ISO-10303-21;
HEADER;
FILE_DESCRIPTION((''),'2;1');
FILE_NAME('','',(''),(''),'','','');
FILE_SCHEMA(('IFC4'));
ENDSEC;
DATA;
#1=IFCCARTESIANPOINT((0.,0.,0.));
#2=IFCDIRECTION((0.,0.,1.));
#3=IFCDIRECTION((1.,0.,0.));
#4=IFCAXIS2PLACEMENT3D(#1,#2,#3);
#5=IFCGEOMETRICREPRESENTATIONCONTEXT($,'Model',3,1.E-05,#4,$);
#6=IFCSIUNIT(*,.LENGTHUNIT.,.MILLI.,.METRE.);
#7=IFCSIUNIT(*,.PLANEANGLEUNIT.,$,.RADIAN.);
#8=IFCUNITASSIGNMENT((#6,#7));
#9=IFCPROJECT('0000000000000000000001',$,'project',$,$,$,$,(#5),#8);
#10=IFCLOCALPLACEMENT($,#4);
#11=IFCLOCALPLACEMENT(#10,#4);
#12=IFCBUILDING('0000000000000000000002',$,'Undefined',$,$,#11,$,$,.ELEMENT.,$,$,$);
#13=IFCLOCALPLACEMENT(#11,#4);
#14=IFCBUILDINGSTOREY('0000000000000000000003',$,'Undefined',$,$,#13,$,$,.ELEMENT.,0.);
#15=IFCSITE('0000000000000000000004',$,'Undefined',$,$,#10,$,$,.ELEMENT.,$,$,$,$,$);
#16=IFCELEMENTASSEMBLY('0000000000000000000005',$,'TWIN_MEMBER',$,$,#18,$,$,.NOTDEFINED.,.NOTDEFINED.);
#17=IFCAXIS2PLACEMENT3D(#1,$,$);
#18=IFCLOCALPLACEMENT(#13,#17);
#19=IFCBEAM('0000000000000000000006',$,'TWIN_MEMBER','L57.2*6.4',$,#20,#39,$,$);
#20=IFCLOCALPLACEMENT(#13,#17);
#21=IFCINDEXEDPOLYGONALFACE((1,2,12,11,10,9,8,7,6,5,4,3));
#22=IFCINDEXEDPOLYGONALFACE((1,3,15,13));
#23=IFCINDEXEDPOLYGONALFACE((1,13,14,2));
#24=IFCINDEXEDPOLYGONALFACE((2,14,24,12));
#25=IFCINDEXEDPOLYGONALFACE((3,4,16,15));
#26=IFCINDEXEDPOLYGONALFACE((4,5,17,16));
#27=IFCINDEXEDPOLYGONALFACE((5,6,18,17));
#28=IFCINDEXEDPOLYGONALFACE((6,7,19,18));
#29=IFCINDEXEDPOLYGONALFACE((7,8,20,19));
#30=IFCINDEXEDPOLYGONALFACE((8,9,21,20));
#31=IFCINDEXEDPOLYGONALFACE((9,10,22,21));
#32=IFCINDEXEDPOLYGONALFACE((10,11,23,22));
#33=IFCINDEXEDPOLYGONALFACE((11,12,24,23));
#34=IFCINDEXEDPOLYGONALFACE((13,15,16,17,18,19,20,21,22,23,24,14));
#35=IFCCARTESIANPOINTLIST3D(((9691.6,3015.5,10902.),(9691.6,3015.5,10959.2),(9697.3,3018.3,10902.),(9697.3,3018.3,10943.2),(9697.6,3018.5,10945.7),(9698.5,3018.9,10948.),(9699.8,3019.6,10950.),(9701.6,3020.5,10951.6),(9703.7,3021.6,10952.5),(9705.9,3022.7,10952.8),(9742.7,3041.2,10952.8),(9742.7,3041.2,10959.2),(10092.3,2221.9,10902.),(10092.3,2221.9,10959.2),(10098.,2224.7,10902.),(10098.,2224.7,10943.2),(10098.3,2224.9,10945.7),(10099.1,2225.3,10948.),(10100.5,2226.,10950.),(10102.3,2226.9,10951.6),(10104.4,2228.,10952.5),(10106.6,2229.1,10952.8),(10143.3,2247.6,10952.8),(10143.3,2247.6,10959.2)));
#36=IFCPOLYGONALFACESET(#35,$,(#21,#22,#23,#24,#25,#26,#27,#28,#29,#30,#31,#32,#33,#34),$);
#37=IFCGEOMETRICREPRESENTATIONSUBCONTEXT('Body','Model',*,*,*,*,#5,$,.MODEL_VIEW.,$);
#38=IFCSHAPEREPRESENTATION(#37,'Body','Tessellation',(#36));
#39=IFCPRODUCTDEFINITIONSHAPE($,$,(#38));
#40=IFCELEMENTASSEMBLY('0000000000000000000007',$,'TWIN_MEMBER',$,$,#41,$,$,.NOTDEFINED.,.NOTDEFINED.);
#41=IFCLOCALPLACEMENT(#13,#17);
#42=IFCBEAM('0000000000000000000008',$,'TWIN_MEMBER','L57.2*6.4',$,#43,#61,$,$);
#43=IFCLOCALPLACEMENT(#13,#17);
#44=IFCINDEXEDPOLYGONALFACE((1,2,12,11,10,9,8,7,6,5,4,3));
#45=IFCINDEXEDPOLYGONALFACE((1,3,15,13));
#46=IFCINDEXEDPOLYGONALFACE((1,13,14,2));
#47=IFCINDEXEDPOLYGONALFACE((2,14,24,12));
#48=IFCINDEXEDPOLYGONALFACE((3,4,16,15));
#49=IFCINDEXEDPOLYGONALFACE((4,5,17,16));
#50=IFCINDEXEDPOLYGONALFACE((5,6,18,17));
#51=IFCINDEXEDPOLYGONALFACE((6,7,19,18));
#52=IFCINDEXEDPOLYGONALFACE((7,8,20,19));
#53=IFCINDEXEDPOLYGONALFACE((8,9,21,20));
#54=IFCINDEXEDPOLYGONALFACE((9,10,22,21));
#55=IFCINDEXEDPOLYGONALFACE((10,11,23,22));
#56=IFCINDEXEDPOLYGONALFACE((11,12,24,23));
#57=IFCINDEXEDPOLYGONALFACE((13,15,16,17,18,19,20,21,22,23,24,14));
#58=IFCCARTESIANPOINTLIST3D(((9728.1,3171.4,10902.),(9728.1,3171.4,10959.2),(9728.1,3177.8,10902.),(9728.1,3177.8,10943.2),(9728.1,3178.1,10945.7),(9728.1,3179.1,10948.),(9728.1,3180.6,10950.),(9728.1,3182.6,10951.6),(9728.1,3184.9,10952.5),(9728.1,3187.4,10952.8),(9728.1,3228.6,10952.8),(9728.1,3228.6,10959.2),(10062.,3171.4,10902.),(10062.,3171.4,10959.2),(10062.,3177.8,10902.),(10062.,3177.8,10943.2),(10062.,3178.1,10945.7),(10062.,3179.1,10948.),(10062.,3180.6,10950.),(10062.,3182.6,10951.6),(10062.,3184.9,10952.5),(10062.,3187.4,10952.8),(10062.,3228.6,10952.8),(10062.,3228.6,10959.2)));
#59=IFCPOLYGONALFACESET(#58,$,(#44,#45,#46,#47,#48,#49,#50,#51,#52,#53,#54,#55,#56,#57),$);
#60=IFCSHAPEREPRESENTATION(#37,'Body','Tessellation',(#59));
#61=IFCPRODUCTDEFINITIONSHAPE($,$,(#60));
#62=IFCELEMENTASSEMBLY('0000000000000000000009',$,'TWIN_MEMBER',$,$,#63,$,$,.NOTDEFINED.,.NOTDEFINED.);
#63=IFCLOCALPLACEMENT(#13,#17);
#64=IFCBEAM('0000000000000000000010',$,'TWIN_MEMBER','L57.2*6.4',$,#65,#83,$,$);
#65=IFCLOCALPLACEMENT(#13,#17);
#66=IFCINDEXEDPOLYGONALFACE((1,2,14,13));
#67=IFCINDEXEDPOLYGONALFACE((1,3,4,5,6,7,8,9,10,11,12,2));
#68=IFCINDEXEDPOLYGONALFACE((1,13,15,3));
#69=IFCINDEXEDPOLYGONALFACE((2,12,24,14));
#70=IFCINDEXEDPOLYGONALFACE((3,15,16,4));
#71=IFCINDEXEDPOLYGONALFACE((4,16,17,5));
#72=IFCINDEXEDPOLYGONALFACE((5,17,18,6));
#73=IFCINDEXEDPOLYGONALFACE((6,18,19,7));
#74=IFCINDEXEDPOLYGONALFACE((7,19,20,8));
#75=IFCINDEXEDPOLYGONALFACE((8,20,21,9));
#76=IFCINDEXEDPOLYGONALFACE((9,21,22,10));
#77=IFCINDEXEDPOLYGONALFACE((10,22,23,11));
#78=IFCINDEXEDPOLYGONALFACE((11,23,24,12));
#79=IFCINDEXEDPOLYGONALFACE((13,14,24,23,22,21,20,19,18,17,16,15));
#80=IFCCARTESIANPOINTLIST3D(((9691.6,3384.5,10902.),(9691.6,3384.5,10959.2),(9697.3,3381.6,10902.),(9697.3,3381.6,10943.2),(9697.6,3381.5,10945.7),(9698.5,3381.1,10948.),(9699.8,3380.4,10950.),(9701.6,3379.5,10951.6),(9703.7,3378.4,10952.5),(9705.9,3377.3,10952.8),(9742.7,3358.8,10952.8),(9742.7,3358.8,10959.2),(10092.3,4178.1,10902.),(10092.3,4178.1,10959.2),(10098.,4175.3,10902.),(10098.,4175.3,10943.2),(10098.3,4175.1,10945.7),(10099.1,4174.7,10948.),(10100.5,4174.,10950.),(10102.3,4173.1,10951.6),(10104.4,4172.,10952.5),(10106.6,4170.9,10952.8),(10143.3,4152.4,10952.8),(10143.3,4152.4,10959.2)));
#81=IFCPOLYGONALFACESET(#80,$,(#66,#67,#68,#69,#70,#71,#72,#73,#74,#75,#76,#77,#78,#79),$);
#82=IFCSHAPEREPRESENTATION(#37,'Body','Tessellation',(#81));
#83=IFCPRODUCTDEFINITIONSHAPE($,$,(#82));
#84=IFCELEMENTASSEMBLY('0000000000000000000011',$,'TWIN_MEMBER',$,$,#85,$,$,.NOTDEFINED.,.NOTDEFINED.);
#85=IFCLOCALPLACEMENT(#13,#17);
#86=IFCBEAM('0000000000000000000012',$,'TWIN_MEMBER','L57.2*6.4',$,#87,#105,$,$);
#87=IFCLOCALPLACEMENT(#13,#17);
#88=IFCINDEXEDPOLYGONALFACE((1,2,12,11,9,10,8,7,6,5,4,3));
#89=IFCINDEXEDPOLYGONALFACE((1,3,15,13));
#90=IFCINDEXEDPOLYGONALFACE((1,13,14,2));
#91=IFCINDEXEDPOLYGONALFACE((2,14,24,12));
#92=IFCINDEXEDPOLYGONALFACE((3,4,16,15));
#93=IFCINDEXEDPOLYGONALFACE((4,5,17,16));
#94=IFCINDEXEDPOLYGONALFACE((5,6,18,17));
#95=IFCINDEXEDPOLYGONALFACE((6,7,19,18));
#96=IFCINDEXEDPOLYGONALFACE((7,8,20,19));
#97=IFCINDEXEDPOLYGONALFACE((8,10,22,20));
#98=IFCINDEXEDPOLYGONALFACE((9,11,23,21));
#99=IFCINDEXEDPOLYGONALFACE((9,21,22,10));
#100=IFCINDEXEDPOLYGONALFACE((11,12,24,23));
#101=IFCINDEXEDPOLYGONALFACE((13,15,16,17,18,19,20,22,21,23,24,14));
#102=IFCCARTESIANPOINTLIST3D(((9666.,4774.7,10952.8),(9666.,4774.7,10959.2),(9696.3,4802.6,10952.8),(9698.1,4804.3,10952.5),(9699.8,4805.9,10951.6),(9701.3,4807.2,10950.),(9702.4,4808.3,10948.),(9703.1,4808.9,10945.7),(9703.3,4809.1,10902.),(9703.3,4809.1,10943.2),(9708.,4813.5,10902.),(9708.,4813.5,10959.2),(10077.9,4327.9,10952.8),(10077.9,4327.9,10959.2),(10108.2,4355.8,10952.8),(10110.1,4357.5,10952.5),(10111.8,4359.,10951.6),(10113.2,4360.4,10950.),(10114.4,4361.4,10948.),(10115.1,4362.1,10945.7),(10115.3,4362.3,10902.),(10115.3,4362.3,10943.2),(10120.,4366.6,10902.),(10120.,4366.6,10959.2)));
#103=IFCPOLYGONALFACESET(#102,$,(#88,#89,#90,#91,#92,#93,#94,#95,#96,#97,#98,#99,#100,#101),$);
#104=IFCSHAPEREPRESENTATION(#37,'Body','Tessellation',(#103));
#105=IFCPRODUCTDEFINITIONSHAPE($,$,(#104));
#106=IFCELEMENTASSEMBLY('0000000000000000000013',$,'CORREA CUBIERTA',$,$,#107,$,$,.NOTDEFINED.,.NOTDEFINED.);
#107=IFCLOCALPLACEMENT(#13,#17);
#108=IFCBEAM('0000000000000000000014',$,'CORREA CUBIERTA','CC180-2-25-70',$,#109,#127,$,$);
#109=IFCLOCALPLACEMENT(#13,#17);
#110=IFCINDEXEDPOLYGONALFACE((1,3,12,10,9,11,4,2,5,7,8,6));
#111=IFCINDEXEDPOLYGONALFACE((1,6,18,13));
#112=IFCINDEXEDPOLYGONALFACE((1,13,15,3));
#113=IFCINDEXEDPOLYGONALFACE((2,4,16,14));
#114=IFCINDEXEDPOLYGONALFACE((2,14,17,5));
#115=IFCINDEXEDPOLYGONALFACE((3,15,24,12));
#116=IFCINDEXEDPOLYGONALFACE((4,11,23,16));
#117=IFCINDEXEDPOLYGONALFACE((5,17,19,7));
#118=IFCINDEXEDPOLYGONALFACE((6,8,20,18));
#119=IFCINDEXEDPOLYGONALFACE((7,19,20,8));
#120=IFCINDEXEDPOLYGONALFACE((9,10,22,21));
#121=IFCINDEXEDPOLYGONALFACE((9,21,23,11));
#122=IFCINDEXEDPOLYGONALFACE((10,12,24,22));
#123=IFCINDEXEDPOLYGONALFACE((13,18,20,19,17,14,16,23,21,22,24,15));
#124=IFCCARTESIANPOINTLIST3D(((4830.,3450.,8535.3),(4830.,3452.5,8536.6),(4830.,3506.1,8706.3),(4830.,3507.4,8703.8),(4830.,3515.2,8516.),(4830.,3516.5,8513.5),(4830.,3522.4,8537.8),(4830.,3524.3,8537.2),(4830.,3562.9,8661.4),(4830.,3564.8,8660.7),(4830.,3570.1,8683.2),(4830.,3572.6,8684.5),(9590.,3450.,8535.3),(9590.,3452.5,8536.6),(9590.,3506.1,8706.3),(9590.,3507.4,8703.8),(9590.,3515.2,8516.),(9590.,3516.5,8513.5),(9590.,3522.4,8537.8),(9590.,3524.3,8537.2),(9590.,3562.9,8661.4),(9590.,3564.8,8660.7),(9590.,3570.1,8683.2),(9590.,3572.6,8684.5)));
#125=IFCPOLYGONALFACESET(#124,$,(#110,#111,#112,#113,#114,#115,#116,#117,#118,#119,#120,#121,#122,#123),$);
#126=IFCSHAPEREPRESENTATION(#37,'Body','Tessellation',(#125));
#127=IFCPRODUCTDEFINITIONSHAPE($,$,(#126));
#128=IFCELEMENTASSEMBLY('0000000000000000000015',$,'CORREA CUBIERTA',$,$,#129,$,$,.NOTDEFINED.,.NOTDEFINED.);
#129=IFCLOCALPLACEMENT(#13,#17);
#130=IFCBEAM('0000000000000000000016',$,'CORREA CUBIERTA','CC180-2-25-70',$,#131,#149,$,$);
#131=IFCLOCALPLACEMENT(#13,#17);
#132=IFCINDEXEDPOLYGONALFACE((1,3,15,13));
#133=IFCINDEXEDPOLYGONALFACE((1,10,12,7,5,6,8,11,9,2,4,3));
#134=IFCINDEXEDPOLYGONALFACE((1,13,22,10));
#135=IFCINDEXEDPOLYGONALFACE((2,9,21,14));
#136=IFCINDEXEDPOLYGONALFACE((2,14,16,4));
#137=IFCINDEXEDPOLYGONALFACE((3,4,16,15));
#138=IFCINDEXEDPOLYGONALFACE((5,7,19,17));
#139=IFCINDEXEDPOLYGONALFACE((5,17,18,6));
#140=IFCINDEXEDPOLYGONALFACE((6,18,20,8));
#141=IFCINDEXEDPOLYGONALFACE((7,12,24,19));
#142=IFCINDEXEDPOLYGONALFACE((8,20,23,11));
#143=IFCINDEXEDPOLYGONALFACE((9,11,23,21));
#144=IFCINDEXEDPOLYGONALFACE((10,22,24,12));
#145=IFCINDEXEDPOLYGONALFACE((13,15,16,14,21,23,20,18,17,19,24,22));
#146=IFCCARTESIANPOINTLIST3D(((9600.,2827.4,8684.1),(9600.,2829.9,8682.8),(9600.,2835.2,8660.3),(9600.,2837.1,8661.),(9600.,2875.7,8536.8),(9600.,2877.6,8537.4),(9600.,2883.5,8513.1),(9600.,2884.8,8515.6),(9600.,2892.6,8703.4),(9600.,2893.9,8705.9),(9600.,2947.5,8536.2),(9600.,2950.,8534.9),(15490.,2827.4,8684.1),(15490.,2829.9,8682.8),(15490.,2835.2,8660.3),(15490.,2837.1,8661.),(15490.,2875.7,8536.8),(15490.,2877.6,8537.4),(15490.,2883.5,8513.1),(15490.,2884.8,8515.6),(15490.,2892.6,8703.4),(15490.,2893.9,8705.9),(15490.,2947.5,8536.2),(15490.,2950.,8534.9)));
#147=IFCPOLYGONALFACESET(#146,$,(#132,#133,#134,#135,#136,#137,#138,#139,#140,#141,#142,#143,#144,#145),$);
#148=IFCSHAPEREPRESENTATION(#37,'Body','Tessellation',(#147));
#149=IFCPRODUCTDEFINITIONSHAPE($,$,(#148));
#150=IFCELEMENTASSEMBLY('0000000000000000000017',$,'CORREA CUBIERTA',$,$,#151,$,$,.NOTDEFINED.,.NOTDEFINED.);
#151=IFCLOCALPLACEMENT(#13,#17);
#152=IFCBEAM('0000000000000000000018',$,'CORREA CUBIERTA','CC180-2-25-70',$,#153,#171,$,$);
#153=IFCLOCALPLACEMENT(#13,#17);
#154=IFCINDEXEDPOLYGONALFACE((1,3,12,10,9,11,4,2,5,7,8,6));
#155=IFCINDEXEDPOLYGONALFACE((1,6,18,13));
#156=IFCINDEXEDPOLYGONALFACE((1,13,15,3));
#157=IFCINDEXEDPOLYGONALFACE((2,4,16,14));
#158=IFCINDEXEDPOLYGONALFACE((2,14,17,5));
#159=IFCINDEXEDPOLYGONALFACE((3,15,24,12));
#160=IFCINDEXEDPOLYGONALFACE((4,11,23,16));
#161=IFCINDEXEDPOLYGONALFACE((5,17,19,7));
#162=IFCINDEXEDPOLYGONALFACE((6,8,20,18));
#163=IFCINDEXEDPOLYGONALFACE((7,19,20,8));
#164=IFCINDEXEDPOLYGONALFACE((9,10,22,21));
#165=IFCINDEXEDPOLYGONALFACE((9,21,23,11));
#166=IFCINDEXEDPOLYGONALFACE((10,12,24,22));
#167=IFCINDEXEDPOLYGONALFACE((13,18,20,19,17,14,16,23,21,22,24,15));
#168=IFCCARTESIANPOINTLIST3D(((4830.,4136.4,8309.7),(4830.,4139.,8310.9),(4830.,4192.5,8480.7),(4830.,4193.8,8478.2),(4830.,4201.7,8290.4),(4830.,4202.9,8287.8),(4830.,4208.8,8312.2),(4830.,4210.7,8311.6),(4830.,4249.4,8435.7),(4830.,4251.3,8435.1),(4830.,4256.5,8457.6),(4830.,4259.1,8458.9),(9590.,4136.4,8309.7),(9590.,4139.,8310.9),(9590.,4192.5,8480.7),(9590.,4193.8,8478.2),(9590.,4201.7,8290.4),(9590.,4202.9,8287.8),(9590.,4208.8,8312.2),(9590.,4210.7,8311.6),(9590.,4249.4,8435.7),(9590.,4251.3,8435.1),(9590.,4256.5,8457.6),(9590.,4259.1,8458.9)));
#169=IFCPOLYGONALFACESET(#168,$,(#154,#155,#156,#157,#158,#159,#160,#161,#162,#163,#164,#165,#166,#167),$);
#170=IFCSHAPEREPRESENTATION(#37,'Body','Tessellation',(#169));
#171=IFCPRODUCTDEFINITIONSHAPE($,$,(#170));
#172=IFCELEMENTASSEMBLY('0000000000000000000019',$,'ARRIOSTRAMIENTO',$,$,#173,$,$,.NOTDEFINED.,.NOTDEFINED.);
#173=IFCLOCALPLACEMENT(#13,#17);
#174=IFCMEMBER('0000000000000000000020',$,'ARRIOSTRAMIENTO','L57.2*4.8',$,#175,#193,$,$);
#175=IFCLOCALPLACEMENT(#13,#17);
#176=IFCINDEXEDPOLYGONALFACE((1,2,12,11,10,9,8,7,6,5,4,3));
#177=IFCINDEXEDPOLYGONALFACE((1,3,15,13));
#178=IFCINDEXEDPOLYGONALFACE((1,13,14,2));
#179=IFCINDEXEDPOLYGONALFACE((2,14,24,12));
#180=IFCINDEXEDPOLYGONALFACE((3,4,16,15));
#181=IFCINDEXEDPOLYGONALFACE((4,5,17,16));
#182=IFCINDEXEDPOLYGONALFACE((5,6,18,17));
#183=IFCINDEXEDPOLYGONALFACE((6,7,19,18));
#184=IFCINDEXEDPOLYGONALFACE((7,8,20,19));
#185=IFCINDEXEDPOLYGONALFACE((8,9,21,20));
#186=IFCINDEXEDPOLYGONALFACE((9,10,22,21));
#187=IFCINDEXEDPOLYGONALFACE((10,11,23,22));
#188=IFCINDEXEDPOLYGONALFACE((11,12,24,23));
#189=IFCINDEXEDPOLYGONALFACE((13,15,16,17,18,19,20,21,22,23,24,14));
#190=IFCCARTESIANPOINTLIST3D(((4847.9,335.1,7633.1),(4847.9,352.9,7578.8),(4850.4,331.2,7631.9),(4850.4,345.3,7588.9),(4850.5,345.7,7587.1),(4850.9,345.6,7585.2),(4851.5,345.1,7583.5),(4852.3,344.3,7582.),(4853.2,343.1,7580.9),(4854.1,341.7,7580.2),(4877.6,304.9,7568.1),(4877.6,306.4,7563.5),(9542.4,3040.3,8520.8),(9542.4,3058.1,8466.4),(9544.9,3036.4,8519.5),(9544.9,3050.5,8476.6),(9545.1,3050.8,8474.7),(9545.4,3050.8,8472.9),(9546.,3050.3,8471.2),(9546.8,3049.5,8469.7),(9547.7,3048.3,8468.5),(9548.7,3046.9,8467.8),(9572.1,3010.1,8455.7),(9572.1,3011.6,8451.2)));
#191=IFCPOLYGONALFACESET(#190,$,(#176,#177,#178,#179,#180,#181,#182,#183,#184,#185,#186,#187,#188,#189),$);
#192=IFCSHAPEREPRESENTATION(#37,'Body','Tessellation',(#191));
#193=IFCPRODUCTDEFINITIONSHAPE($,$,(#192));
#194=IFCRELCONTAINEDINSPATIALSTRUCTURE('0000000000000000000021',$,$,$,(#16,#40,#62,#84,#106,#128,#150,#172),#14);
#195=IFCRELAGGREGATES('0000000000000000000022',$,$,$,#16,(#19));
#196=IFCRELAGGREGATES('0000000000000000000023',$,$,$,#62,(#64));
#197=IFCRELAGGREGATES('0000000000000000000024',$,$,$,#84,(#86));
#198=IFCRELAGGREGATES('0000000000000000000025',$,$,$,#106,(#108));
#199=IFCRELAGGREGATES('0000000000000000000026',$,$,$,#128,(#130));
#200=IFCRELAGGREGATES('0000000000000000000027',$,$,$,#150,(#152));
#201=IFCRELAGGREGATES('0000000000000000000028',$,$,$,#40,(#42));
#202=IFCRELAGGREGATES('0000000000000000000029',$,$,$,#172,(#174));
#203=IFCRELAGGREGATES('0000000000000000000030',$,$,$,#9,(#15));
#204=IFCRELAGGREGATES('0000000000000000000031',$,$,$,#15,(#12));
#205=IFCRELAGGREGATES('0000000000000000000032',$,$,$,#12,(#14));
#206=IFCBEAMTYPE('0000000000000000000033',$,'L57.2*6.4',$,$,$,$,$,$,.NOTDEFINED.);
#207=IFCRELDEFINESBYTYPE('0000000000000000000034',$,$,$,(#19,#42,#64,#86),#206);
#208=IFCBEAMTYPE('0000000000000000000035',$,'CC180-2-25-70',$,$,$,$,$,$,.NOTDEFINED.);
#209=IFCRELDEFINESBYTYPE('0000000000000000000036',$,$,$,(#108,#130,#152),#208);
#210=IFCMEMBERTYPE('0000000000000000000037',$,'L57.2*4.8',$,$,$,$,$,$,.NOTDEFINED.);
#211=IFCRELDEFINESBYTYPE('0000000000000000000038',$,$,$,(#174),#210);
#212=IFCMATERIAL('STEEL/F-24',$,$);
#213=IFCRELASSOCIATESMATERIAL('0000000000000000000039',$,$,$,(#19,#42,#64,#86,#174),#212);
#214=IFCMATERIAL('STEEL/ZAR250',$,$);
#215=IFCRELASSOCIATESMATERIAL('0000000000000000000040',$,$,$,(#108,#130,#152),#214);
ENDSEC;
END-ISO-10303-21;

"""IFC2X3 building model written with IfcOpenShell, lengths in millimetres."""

from ifc_helpers import new_model, si_unit, frame, origin_with_axes, origin_2d_with_axis, place, context, subcontext, project, spatial, l_section, c_section, extrude, clip, halfspace, material, type_object, element, aggregate, save


model = new_model("IFC2X3")

# Units and contexts
model_context = context("Model", 3, precision=1e-05, world=origin_with_axes())
body_context = subcontext(model_context, "Body", "Model", "MODEL_VIEW")
ifc_project = project(units=[si_unit("LENGTHUNIT", "METRE", prefix="MILLI"), si_unit("PLANEANGLEUNIT", "RADIAN")], contexts=[model_context])

# Site, building, storey
site_placement = place(None, origin_with_axes())
site = spatial("IfcSite", under=ifc_project, at=site_placement, Name="Undefined", CompositionType="ELEMENT")
building_placement = place(site_placement, origin_with_axes())
building = spatial("IfcBuilding", under=site, at=building_placement, Name="Undefined", CompositionType="ELEMENT")
storey_placement = place(building_placement, origin_with_axes())
storey = spatial("IfcBuildingStorey", under=building, at=storey_placement, Name="Undefined", CompositionType="ELEMENT", Elevation=0.0)

# Element assemblies, beams
assembly_1_placement = place(storey_placement, origin_with_axes())
assembly_1 = element("IfcElementAssembly", 1, at=assembly_1_placement, inside=storey, Name="TWIN_MEMBER", AssemblyPlace="NOTDEFINED", PredefinedType="NOTDEFINED")
ifc_material_1 = material(Name="STEEL/F-24")
beam_type_1 = type_object("IfcBeamType", Name="L57.2*6.4", PredefinedType="NOTDEFINED")
beam_1_placement = place(assembly_1_placement, frame((9717.1, 3028.4, 10930.6), z_axis=(0.0, 0.0, -1.0), x_axis=(0.450691, -0.89268, 0.0)))
beam_1 = element("IfcBeam", 2, at=beam_1_placement, type_object=beam_type_1, material=ifc_material_1, Name="TWIN_MEMBER", Description="L57.2*6.4", context=body_context, shape_type="SweptSolid", body=[
    extrude(l_section(Depth=57.2, Width=57.2, Thickness=6.4, FilletRadius=9.6, at=origin_2d_with_axis()), frame((889.0, 0.0, 0.0), z_axis=(-1.0, 0.0, 0.0), x_axis=(0.0, -1.0, 0.0)), (0.0, 0.0, 1.0), 889.0),
])
aggregate(assembly_1, [beam_1])
assembly_2_placement = place(storey_placement, origin_with_axes())
assembly_2 = element("IfcElementAssembly", 3, at=assembly_2_placement, inside=storey, Name="TWIN_MEMBER", AssemblyPlace="NOTDEFINED", PredefinedType="NOTDEFINED")
beam_2_placement = place(assembly_2_placement, frame((9728.1, 3200.0, 10930.6), z_axis=(0.0, 0.0, -1.0), x_axis=(1.0, 0.0, 0.0)))
beam_2 = element("IfcBeam", 4, at=beam_2_placement, type_object=beam_type_1, material=ifc_material_1, Name="TWIN_MEMBER", Description="L57.2*6.4", context=body_context, shape_type="SweptSolid", body=[
    extrude(l_section(Depth=57.2, Width=57.2, Thickness=6.4, FilletRadius=9.6, at=origin_2d_with_axis()), frame((333.9, 0.0, 0.0), z_axis=(-1.0, 0.0, 0.0), x_axis=(0.0, -1.0, 0.0)), (0.0, 0.0, 1.0), 333.9),
])
assembly_3_placement = place(storey_placement, origin_with_axes())
assembly_3 = element("IfcElementAssembly", 5, at=assembly_3_placement, inside=storey, Name="TWIN_MEMBER", AssemblyPlace="NOTDEFINED", PredefinedType="NOTDEFINED")
beam_3_placement = place(assembly_3_placement, frame((10117.8, 4165.2, 10930.6), z_axis=(0.0, 0.0, -1.0), x_axis=(-0.450691, -0.89268, 0.0)))
beam_3 = element("IfcBeam", 6, at=beam_3_placement, type_object=beam_type_1, material=ifc_material_1, Name="TWIN_MEMBER", Description="L57.2*6.4", context=body_context, shape_type="SweptSolid", body=[
    extrude(l_section(Depth=57.2, Width=57.2, Thickness=6.4, FilletRadius=9.6, at=origin_2d_with_axis()), frame((889.0, 0.0, 0.0), z_axis=(-1.0, 0.0, 0.0), x_axis=(0.0, -1.0, 0.0)), (0.0, 0.0, 1.0), 889.0),
])
aggregate(assembly_3, [beam_3])
assembly_4_placement = place(storey_placement, origin_with_axes())
assembly_4 = element("IfcElementAssembly", 7, at=assembly_4_placement, inside=storey, Name="TWIN_MEMBER", AssemblyPlace="NOTDEFINED", PredefinedType="NOTDEFINED")
beam_4_placement = place(assembly_4_placement, frame((10099.0, 4347.3, 10930.6), z_axis=(0.0, 0.0, -1.0), x_axis=(-0.677842, 0.735208, 0.0)))
beam_4 = element("IfcBeam", 8, at=beam_4_placement, type_object=beam_type_1, material=ifc_material_1, Name="TWIN_MEMBER", Description="L57.2*6.4", context=body_context, shape_type="SweptSolid", body=[
    extrude(l_section(Depth=57.2, Width=57.2, Thickness=6.4, FilletRadius=9.6, at=origin_2d_with_axis()), frame((607.8, 0.0, 0.0), z_axis=(-1.0, 0.0, 0.0), x_axis=(0.0, -1.0, 0.0)), (0.0, 0.0, 1.0), 607.8),
])
aggregate(assembly_4, [beam_4])
assembly_5_placement = place(storey_placement, origin_with_axes())
assembly_5 = element("IfcElementAssembly", 9, at=assembly_5_placement, inside=storey, Name="CORREA CUBIERTA", AssemblyPlace="NOTDEFINED", PredefinedType="NOTDEFINED")
ifc_material_2 = material(Name="STEEL/ZAR250")
beam_type_2 = type_object("IfcBeamType", Name="CC180-2-25-70", PredefinedType="NOTDEFINED")
beam_5_placement = place(assembly_5_placement, frame((9590.0, 3511.3, 8609.9), z_axis=(0.0, 0.311771, 0.950157), x_axis=(-1.0, 0.0, 0.0)))
beam_5 = element("IfcBeam", 10, at=beam_5_placement, type_object=beam_type_2, material=ifc_material_2, Name="CORREA CUBIERTA", Description="CC180-2-25-70", context=body_context, shape_type="SweptSolid", body=[
    extrude(c_section(Depth=180.0, Width=70.0, WallThickness=2.0, Girth=25.0, at=origin_2d_with_axis()), frame((4760.0, 0.0, 0.0), z_axis=(-1.0, 0.0, 0.0), x_axis=(0.0, -1.0, 0.0)), (0.0, 0.0, 1.0), 4760.0),
])
aggregate(assembly_5, [beam_5])
assembly_6_placement = place(storey_placement, origin_with_axes())
assembly_6 = element("IfcElementAssembly", 11, at=assembly_6_placement, inside=storey, Name="CORREA CUBIERTA", AssemblyPlace="NOTDEFINED", PredefinedType="NOTDEFINED")
beam_6_placement = place(assembly_6_placement, frame((9600.0, 2888.7, 8609.5), z_axis=(0.0, -0.311771, 0.950157), x_axis=(1.0, 0.0, 0.0)))
beam_6 = element("IfcBeam", 12, at=beam_6_placement, type_object=beam_type_2, material=ifc_material_2, Name="CORREA CUBIERTA", Description="CC180-2-25-70", context=body_context, shape_type="SweptSolid", body=[
    extrude(c_section(Depth=180.0, Width=70.0, WallThickness=2.0, Girth=25.0, at=origin_2d_with_axis()), frame((5890.0, 0.0, 0.0), z_axis=(-1.0, 0.0, 0.0), x_axis=(0.0, -1.0, 0.0)), (0.0, 0.0, 1.0), 5890.0),
])
aggregate(assembly_6, [beam_6])
assembly_7_placement = place(storey_placement, origin_with_axes())
assembly_7 = element("IfcElementAssembly", 13, at=assembly_7_placement, inside=storey, Name="CORREA CUBIERTA", AssemblyPlace="NOTDEFINED", PredefinedType="NOTDEFINED")
beam_7_placement = place(assembly_7_placement, frame((9590.0, 4197.7, 8384.3), z_axis=(0.0, 0.311771, 0.950157), x_axis=(-1.0, 0.0, 0.0)))
beam_7 = element("IfcBeam", 14, at=beam_7_placement, type_object=beam_type_2, material=ifc_material_2, Name="CORREA CUBIERTA", Description="CC180-2-25-70", context=body_context, shape_type="SweptSolid", body=[
    extrude(c_section(Depth=180.0, Width=70.0, WallThickness=2.0, Girth=25.0, at=origin_2d_with_axis()), frame((4760.0, 0.0, 0.0), z_axis=(-1.0, 0.0, 0.0), x_axis=(0.0, -1.0, 0.0)), (0.0, 0.0, 1.0), 4760.0),
])
aggregate(assembly_7, [beam_7])

# Element assembly, member
assembly_8_placement = place(storey_placement, origin_with_axes())
assembly_8 = element("IfcElementAssembly", 15, at=assembly_8_placement, inside=storey, Name="ARRIOSTRAMIENTO", AssemblyPlace="NOTDEFINED", PredefinedType="NOTDEFINED")
member_type = type_object("IfcMemberType", Name="L57.2*4.8", PredefinedType="NOTDEFINED")
member_1_placement = place(assembly_8_placement, frame((9595.0, 3047.7, 8493.1), z_axis=(0.518558, -0.812425, -0.266577), x_axis=(-0.855043, -0.492712, -0.161671)))
member_1 = element("IfcMember", 16, at=member_1_placement, type_object=member_type, material=ifc_material_1, Name="ARRIOSTRAMIENTO", Description="L57.2*4.8", context=body_context, shape_type="Clipping", body=[
    clip(clip(extrude(l_section(Depth=57.2, Width=57.2, Thickness=4.8, FilletRadius=7.2, at=origin_2d_with_axis()), frame((5595.4, 0.0, 0.0), z_axis=(-1.0, 0.0, 0.0), x_axis=(0.0, -1.0, 0.0)), (0.0, 0.0, 1.0), 5612.1), halfspace(frame((5534.5, 28.6, 0.0), z_axis=(-1.0, 0.0, 0.0), x_axis=(0.0, 0.0, 1.0)), True)), halfspace(frame((44.1, 38.1, 0.0), z_axis=(1.0, 0.0, 0.0), x_axis=(0.0, 0.0, -1.0)), True)),
])

aggregate(assembly_2, [beam_2])

aggregate(assembly_8, [member_1])

save(model, "model.ifc")
